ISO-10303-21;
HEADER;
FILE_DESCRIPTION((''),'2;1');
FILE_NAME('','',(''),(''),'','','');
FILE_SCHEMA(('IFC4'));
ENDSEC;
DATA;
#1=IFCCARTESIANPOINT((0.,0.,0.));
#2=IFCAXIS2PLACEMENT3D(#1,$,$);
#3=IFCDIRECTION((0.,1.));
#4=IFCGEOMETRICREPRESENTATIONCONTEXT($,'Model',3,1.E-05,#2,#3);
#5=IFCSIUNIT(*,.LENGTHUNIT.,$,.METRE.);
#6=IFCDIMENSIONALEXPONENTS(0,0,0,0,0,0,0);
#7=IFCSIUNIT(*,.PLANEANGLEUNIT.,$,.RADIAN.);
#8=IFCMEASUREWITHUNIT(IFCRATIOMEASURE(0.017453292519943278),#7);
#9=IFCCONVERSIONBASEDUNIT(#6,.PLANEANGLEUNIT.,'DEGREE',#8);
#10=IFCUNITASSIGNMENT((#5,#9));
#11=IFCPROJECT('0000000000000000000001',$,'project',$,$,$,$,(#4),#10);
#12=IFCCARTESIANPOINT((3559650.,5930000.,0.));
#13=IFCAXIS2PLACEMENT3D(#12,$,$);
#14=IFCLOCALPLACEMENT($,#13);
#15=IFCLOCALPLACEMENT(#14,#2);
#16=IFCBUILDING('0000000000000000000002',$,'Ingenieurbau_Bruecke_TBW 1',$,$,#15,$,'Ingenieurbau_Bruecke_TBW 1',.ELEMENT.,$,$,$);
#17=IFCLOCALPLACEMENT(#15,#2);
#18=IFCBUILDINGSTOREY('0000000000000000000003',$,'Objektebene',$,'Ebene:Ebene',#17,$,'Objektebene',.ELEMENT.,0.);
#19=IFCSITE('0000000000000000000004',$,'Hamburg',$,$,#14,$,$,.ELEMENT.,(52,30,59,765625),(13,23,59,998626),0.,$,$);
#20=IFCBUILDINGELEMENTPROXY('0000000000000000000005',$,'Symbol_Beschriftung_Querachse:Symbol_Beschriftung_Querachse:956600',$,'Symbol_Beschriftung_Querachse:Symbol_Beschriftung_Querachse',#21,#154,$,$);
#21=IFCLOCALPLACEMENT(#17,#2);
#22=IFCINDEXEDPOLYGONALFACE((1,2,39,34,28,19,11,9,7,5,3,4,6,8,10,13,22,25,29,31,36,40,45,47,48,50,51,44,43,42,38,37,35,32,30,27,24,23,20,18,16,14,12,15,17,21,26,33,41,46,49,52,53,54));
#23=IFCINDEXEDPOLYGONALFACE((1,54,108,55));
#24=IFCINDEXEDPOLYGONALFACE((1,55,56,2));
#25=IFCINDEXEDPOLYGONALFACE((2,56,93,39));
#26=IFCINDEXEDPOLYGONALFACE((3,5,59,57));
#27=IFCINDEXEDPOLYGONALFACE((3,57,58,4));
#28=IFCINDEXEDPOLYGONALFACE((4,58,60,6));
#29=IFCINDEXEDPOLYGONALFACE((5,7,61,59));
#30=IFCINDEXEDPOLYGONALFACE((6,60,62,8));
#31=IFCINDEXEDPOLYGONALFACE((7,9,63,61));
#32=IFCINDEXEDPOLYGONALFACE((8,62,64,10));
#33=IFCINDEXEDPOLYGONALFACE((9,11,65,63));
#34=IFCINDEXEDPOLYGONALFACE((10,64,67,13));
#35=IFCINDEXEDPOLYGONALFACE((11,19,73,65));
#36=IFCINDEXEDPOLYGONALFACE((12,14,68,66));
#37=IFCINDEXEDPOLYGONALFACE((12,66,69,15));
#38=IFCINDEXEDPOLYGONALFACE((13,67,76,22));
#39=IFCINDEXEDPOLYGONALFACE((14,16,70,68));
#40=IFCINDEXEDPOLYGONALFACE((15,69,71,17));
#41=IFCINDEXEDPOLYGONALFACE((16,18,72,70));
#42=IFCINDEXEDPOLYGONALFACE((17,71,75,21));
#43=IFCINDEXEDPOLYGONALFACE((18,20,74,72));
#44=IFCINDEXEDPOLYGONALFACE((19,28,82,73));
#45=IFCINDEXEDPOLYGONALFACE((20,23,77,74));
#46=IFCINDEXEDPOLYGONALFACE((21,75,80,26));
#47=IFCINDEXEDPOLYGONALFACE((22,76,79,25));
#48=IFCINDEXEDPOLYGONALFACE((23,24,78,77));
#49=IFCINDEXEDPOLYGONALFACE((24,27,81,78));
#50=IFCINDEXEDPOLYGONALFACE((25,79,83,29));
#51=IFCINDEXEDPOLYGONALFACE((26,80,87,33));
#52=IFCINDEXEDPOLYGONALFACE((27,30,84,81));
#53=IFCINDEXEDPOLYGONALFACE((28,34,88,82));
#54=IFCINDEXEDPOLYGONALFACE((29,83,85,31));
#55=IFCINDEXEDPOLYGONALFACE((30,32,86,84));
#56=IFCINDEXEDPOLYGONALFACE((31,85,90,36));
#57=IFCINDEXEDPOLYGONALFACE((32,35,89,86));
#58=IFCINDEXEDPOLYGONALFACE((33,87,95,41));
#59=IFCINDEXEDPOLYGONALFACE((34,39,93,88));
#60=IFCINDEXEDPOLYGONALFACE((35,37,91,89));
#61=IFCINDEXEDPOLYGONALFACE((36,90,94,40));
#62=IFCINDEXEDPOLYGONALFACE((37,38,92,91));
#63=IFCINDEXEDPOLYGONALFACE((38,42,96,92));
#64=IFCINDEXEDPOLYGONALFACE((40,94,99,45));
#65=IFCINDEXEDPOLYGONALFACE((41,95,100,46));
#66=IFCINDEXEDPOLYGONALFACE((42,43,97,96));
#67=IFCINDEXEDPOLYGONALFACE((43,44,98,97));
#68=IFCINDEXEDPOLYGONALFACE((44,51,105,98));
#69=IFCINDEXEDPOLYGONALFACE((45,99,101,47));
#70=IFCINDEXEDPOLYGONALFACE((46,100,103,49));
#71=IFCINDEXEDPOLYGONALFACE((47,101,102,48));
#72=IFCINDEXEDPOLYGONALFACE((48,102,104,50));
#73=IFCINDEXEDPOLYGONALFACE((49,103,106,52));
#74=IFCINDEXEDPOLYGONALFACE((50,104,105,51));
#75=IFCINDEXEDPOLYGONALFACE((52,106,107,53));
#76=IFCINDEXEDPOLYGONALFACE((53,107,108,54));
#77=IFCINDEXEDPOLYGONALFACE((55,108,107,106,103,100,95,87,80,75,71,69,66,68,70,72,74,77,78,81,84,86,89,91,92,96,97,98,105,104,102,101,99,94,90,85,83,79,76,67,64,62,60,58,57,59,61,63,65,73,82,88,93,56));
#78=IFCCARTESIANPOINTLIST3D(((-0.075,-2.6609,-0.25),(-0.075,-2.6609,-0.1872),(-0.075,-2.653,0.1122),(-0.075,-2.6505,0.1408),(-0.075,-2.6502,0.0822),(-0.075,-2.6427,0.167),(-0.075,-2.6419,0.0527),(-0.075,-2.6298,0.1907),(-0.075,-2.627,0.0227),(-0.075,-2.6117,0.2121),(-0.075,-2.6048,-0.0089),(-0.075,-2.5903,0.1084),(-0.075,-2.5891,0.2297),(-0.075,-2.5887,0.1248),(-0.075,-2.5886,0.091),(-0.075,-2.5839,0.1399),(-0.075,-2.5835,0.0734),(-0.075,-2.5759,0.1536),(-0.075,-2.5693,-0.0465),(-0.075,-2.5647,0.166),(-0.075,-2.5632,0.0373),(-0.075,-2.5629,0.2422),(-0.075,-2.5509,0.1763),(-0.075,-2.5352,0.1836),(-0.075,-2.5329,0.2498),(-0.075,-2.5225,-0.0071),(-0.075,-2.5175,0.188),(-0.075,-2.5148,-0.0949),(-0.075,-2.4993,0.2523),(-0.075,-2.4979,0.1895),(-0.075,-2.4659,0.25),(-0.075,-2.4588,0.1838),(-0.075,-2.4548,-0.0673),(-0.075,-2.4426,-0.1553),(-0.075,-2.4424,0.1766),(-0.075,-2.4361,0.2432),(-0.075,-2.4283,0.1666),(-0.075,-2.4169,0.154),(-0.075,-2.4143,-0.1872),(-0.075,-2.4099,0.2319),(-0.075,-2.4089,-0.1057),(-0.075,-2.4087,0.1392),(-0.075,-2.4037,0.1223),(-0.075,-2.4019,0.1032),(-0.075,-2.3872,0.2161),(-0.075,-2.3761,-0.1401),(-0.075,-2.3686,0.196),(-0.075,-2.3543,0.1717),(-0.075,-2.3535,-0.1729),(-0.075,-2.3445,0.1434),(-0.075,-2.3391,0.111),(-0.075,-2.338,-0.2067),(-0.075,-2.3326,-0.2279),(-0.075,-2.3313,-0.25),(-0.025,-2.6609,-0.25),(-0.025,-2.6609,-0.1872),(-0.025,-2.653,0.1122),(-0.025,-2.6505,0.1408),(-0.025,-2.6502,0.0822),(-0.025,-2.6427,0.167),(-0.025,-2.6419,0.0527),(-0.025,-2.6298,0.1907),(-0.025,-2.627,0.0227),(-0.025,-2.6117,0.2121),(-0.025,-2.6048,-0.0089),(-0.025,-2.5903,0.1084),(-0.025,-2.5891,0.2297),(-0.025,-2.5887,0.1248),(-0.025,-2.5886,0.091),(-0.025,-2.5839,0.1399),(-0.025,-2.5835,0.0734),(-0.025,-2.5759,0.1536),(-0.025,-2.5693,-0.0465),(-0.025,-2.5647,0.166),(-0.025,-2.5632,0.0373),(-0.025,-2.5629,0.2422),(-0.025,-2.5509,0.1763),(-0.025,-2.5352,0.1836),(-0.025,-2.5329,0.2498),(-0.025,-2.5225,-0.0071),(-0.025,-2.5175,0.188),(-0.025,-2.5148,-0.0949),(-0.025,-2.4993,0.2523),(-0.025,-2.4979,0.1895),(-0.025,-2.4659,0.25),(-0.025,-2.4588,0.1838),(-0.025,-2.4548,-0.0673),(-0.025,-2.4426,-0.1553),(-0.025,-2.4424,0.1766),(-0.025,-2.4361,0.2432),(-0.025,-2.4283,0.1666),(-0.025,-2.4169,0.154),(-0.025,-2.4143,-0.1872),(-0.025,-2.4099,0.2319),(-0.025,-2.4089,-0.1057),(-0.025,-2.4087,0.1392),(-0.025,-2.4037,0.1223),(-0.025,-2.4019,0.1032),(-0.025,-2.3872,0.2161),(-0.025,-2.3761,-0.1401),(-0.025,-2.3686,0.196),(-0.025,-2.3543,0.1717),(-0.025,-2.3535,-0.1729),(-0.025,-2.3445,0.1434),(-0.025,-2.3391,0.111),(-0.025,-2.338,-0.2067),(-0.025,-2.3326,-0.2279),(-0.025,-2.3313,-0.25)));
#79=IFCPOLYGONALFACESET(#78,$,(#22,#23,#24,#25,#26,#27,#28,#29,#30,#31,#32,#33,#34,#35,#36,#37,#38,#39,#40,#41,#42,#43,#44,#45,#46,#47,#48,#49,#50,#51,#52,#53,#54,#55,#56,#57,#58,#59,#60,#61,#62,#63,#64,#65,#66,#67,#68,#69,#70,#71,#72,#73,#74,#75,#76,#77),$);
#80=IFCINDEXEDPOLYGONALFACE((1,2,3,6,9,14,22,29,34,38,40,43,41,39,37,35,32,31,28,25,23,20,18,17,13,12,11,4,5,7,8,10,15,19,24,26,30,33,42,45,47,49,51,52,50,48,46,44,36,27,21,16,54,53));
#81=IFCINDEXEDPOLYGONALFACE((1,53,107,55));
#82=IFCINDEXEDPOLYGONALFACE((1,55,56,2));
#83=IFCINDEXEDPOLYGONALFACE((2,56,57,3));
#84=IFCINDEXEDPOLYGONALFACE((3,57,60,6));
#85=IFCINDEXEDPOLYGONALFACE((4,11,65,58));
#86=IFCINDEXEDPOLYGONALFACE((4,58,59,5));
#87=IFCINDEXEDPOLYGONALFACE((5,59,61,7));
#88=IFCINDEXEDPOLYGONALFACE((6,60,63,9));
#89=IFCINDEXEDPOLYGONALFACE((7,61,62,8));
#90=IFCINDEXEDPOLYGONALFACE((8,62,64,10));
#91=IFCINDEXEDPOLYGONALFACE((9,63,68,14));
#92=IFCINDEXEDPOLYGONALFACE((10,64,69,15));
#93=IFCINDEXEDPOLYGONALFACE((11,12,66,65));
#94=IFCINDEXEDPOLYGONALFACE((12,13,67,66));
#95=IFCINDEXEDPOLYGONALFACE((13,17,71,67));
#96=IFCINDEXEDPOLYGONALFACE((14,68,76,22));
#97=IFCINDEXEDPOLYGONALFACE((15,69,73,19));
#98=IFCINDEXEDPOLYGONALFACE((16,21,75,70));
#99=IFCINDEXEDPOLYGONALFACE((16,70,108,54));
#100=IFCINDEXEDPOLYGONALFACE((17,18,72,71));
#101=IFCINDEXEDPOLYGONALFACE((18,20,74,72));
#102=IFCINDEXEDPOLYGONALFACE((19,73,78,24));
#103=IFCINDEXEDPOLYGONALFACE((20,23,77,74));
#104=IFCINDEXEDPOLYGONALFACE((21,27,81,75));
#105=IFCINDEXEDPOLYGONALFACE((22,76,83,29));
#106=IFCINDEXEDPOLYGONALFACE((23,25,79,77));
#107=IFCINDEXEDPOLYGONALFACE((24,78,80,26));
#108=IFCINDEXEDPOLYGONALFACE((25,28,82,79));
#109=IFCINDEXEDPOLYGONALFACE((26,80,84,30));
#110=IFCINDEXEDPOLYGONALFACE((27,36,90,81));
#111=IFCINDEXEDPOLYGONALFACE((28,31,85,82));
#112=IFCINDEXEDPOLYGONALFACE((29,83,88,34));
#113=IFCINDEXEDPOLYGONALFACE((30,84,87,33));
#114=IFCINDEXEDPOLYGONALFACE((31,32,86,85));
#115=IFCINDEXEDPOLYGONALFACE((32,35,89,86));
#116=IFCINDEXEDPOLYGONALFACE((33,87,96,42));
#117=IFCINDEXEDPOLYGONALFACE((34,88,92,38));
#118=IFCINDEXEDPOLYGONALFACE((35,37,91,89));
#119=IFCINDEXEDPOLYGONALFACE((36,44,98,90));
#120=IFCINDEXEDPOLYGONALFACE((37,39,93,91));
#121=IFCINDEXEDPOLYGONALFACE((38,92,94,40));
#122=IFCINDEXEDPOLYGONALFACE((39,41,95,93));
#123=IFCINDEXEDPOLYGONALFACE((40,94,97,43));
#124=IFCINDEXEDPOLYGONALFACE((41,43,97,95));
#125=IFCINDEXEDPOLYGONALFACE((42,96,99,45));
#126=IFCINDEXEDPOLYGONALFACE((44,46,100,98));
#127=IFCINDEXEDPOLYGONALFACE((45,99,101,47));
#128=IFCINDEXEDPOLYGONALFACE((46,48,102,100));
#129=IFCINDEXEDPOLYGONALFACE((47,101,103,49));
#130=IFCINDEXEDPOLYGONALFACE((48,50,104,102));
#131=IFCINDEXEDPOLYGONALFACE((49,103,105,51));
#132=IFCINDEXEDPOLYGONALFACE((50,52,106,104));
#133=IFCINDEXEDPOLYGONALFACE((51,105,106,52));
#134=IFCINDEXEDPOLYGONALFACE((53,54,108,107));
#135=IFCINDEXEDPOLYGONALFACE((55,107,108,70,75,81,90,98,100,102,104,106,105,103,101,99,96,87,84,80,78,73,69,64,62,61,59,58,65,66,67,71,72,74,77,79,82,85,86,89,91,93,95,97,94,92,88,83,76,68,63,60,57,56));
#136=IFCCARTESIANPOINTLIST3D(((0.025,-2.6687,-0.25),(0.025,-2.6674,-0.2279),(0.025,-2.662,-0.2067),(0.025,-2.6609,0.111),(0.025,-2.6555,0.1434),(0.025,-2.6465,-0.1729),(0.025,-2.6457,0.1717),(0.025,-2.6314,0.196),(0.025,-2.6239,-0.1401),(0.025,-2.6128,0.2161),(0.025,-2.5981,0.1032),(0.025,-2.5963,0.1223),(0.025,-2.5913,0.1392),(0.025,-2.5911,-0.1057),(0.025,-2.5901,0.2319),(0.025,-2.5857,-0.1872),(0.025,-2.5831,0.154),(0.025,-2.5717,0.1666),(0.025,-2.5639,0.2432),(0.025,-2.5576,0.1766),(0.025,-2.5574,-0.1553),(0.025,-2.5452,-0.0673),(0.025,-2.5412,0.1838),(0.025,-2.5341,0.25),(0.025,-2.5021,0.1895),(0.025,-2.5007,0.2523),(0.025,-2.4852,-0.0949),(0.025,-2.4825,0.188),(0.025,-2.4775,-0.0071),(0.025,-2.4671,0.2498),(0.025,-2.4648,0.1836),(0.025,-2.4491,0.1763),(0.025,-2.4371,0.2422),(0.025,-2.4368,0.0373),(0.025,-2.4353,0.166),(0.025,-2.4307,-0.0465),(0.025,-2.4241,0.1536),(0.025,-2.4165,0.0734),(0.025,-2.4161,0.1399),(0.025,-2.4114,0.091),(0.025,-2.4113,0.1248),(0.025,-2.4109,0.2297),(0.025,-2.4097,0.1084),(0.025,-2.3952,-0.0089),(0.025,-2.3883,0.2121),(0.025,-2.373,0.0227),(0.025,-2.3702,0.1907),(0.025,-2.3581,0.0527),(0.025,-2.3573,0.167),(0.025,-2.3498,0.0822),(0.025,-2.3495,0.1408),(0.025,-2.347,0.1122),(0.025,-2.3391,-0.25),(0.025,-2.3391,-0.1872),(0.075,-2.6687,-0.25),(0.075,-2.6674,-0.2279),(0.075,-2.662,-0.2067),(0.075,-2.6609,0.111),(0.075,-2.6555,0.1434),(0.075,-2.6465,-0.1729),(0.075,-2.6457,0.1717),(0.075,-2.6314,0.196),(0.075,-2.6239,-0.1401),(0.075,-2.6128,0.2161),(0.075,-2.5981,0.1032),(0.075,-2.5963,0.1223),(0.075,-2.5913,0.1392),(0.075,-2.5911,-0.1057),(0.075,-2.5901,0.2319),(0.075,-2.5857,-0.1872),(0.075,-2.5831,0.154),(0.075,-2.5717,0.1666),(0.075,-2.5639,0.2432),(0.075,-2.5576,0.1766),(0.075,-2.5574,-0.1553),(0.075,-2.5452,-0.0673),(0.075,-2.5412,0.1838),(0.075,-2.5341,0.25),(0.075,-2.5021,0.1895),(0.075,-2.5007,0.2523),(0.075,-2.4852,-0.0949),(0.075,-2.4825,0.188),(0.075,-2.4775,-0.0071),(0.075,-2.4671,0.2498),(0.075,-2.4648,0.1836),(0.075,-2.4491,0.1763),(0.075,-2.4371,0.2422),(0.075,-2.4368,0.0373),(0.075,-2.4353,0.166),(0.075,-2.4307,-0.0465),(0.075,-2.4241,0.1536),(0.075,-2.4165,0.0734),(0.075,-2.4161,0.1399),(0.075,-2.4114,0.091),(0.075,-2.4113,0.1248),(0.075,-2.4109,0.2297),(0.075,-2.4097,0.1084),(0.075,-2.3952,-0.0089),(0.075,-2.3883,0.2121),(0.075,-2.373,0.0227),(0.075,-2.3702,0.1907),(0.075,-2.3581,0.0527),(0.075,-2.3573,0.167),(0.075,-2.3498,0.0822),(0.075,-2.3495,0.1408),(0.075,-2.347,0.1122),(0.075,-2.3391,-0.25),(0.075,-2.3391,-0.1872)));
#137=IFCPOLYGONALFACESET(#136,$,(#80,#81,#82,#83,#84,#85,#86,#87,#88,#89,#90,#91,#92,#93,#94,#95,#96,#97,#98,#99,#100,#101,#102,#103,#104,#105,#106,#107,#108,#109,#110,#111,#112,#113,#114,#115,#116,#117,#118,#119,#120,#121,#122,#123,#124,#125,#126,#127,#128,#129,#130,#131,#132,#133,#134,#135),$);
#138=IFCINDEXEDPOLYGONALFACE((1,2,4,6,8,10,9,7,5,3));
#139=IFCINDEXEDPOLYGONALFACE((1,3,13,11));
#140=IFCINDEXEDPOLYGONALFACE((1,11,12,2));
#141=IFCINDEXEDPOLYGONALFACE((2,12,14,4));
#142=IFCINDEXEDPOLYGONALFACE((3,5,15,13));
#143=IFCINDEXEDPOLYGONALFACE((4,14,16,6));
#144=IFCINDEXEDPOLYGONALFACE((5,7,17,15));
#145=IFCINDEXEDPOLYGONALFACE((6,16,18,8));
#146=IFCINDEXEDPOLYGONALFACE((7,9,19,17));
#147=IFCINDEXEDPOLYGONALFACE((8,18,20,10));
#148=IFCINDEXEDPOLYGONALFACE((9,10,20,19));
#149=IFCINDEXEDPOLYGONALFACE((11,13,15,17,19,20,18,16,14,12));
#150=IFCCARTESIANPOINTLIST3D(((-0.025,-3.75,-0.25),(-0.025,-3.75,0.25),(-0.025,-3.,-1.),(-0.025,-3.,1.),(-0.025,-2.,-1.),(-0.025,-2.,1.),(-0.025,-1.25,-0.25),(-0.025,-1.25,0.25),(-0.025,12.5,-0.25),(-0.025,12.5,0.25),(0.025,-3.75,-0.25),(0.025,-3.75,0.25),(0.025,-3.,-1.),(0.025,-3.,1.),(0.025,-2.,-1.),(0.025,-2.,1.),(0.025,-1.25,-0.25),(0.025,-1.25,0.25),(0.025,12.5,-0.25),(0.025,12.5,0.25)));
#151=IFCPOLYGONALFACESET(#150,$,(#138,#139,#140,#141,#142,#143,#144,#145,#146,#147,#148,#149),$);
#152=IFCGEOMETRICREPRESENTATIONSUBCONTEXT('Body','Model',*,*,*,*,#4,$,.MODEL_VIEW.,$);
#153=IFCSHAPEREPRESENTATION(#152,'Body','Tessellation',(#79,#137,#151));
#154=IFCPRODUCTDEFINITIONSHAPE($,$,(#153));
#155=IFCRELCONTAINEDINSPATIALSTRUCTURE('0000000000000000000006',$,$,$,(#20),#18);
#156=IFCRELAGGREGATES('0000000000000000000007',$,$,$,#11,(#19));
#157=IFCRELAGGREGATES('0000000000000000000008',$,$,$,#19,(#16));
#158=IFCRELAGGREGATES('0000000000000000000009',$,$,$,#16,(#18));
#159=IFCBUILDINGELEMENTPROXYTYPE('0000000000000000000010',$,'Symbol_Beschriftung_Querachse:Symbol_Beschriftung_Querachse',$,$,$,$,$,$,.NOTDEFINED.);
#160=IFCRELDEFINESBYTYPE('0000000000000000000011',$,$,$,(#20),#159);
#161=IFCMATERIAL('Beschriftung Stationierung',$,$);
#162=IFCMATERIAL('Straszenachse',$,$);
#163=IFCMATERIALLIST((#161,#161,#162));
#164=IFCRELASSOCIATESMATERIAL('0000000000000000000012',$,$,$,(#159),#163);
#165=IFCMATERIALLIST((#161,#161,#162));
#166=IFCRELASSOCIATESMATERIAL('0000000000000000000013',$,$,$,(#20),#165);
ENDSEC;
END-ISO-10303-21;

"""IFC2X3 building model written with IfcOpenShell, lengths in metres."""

from ifc_helpers import new_model, entity, si_unit, converted_unit, direction, frame, origin, place, context, subcontext, project, spatial, polyline, outline, extrude, source, transform, mapped, material, material_list, type_object, type_shapes, element, save


model = new_model("IFC2X3")

# Units and contexts
model_context = context("Model", 3, precision=1e-05, world=origin(), true_north=direction((0.0, 1.0)))
body_context = subcontext(model_context, "Body", "Model", "MODEL_VIEW")
ifc_project = project(units=[si_unit("LENGTHUNIT", "METRE"), converted_unit("PLANEANGLEUNIT", "DEGREE", entity("IfcRatioMeasure", 0.017453292519943278), si_unit("PLANEANGLEUNIT", "RADIAN"), dimensions=[0, 0, 0, 0, 0, 0, 0])], contexts=[model_context])

# Site, building, storey
site_placement = place(None, frame((3559650.0, 5930000.0, 0.0)))
site = spatial("IfcSite", under=ifc_project, at=site_placement, Name="Hamburg", CompositionType="ELEMENT", RefLatitude=(52, 30, 59, 765625), RefLongitude=(13, 23, 59, 998626), RefElevation=0.0)
building_placement = place(site_placement, origin())
building = spatial("IfcBuilding", under=site, at=building_placement, Name="Ingenieurbau_Bruecke_TBW 1", LongName="Ingenieurbau_Bruecke_TBW 1", CompositionType="ELEMENT")
storey_placement = place(building_placement, origin())
storey = spatial("IfcBuildingStorey", under=building, at=storey_placement, Name="Objektebene", ObjectType="Ebene:Ebene", LongName="Objektebene", CompositionType="ELEMENT", Elevation=0.0)

# Shared definitions
ifc_material_1 = material(Name="Beschriftung Stationierung")
ifc_material_2 = material(Name="Straszenachse")

# Building element proxy
ifc_material_list_1 = material_list([ifc_material_1, ifc_material_1, ifc_material_2])
ifc_material_list_2 = material_list([ifc_material_1, ifc_material_1, ifc_material_2])
building_element_proxy_type_1 = type_object("IfcBuildingElementProxyType", Name="Symbol_Beschriftung_Querachse:Symbol_Beschriftung_Querachse", PredefinedType="NOTDEFINED", material=ifc_material_list_2)
shared_shape_1 = source(origin(), body_context, "Body", "SweptSolid", [
    extrude(outline(polyline([(-0.1594, -0.2629), (-0.1594, -0.3257), (0.1703, -0.3257), (0.1689, -0.3036), (0.1635, -0.2824), (0.148, -0.2486), (0.1254, -0.2158), (0.0926, -0.1814), (0.0468, -0.143), (-0.021, -0.0828), (-0.0616, -0.0384), (-0.0819, -0.0023), (-0.087, 0.0153), (-0.0887, 0.0327), (-0.0871, 0.0491), (-0.0823, 0.0642), (-0.0743, 0.0779), (-0.0632, 0.0903), (-0.0494, 0.1006), (-0.0337, 0.1079), (-0.016, 0.1123), (0.0036, 0.1138), (0.0428, 0.1081), (0.0591, 0.1009), (0.0732, 0.0909), (0.0846, 0.0783), (0.0928, 0.0635), (0.0978, 0.0466), (0.0996, 0.0275), (0.1624, 0.0353), (0.157, 0.0677), (0.1472, 0.096), (0.133, 0.1203), (0.1143, 0.1404), (0.0916, 0.1562), (0.0654, 0.1675), (0.0356, 0.1743), (0.0023, 0.1766), (-0.0314, 0.1741), (-0.0613, 0.1665), (-0.0876, 0.154), (-0.1101, 0.1364), (-0.1282, 0.115), (-0.1412, 0.0913), (-0.1489, 0.0651), (-0.1515, 0.0365), (-0.1487, 0.0065), (-0.1403, -0.023), (-0.1255, -0.053), (-0.1033, -0.0846), (-0.0678, -0.1222), (-0.0133, -0.1706), (0.0589, -0.231), (0.0872, -0.2629), (-0.1594, -0.2629)])), frame((-15.0015, 0.025, 0.0757), z_axis=(0.0, -1.0, 0.0), x_axis=(1.0, 0.0, 0.0)), (0.0, 0.0, -1.0), 0.05),
    extrude(outline(polyline([(0.2629, -0.1594), (0.3257, -0.1594), (0.3257, 0.1703), (0.3036, 0.1689), (0.2824, 0.1635), (0.2486, 0.148), (0.2158, 0.1254), (0.1814, 0.0926), (0.143, 0.0468), (0.0828, -0.021), (0.0384, -0.0616), (0.0023, -0.0819), (-0.0153, -0.087), (-0.0327, -0.0887), (-0.0491, -0.0871), (-0.0642, -0.0823), (-0.0779, -0.0743), (-0.0903, -0.0632), (-0.1006, -0.0494), (-0.1079, -0.0337), (-0.1123, -0.016), (-0.1138, 0.0036), (-0.1081, 0.0428), (-0.1009, 0.0591), (-0.0909, 0.0732), (-0.0783, 0.0846), (-0.0635, 0.0928), (-0.0466, 0.0978), (-0.0275, 0.0996), (-0.0353, 0.1624), (-0.0677, 0.157), (-0.096, 0.1472), (-0.1203, 0.133), (-0.1404, 0.1143), (-0.1562, 0.0916), (-0.1675, 0.0654), (-0.1743, 0.0356), (-0.1766, 0.0023), (-0.1741, -0.0314), (-0.1665, -0.0613), (-0.154, -0.0876), (-0.1364, -0.1101), (-0.115, -0.1282), (-0.0913, -0.1412), (-0.0651, -0.1489), (-0.0365, -0.1515), (-0.0065, -0.1487), (0.023, -0.1403), (0.053, -0.1255), (0.0846, -0.1033), (0.1222, -0.0678), (0.1706, -0.0133), (0.231, 0.0589), (0.2629, 0.0872), (0.2629, -0.1594)])), frame((-14.9985, -0.075, 0.0757), z_axis=(0.0, 1.0, 0.0), x_axis=(0.0, 0.0, -1.0)), (0.0, 0.0, 1.0), 0.05),
    extrude(outline(polyline([(-12.0, 0.25), (-12.0, -0.25), (1.75, -0.25), (2.5, -1.0), (3.5, -1.0), (4.25, -0.25), (4.25, 0.25), (3.5, 1.0), (2.5, 1.0), (1.75, 0.25), (-12.0, 0.25)])), frame((-12.0, -0.025, 0.0), z_axis=(0.0, -1.0, 0.0), x_axis=(-1.0, 0.0, 0.0)), (0.0, 0.0, -1.0), 0.05),
])
type_shapes(building_element_proxy_type_1, [shared_shape_1])
proxy_1_placement = place(storey_placement, frame((0.0, 12.5, 0.0), z_axis=(0.0, 0.0, 1.0), x_axis=(0.0, 1.0, 0.0)))
element("IfcBuildingElementProxy", 1, at=proxy_1_placement, inside=storey, type_object=building_element_proxy_type_1, material=ifc_material_list_1, Name="Symbol_Beschriftung_Querachse:Symbol_Beschriftung_Querachse:956600", ObjectType="Symbol_Beschriftung_Querachse:Symbol_Beschriftung_Querachse", context=body_context, shape_type="MappedRepresentation", body=[
    mapped(shared_shape_1, transform((0.0, 0.0, 0.0), scale=1.0)),
])

save(model, "model.ifc")
